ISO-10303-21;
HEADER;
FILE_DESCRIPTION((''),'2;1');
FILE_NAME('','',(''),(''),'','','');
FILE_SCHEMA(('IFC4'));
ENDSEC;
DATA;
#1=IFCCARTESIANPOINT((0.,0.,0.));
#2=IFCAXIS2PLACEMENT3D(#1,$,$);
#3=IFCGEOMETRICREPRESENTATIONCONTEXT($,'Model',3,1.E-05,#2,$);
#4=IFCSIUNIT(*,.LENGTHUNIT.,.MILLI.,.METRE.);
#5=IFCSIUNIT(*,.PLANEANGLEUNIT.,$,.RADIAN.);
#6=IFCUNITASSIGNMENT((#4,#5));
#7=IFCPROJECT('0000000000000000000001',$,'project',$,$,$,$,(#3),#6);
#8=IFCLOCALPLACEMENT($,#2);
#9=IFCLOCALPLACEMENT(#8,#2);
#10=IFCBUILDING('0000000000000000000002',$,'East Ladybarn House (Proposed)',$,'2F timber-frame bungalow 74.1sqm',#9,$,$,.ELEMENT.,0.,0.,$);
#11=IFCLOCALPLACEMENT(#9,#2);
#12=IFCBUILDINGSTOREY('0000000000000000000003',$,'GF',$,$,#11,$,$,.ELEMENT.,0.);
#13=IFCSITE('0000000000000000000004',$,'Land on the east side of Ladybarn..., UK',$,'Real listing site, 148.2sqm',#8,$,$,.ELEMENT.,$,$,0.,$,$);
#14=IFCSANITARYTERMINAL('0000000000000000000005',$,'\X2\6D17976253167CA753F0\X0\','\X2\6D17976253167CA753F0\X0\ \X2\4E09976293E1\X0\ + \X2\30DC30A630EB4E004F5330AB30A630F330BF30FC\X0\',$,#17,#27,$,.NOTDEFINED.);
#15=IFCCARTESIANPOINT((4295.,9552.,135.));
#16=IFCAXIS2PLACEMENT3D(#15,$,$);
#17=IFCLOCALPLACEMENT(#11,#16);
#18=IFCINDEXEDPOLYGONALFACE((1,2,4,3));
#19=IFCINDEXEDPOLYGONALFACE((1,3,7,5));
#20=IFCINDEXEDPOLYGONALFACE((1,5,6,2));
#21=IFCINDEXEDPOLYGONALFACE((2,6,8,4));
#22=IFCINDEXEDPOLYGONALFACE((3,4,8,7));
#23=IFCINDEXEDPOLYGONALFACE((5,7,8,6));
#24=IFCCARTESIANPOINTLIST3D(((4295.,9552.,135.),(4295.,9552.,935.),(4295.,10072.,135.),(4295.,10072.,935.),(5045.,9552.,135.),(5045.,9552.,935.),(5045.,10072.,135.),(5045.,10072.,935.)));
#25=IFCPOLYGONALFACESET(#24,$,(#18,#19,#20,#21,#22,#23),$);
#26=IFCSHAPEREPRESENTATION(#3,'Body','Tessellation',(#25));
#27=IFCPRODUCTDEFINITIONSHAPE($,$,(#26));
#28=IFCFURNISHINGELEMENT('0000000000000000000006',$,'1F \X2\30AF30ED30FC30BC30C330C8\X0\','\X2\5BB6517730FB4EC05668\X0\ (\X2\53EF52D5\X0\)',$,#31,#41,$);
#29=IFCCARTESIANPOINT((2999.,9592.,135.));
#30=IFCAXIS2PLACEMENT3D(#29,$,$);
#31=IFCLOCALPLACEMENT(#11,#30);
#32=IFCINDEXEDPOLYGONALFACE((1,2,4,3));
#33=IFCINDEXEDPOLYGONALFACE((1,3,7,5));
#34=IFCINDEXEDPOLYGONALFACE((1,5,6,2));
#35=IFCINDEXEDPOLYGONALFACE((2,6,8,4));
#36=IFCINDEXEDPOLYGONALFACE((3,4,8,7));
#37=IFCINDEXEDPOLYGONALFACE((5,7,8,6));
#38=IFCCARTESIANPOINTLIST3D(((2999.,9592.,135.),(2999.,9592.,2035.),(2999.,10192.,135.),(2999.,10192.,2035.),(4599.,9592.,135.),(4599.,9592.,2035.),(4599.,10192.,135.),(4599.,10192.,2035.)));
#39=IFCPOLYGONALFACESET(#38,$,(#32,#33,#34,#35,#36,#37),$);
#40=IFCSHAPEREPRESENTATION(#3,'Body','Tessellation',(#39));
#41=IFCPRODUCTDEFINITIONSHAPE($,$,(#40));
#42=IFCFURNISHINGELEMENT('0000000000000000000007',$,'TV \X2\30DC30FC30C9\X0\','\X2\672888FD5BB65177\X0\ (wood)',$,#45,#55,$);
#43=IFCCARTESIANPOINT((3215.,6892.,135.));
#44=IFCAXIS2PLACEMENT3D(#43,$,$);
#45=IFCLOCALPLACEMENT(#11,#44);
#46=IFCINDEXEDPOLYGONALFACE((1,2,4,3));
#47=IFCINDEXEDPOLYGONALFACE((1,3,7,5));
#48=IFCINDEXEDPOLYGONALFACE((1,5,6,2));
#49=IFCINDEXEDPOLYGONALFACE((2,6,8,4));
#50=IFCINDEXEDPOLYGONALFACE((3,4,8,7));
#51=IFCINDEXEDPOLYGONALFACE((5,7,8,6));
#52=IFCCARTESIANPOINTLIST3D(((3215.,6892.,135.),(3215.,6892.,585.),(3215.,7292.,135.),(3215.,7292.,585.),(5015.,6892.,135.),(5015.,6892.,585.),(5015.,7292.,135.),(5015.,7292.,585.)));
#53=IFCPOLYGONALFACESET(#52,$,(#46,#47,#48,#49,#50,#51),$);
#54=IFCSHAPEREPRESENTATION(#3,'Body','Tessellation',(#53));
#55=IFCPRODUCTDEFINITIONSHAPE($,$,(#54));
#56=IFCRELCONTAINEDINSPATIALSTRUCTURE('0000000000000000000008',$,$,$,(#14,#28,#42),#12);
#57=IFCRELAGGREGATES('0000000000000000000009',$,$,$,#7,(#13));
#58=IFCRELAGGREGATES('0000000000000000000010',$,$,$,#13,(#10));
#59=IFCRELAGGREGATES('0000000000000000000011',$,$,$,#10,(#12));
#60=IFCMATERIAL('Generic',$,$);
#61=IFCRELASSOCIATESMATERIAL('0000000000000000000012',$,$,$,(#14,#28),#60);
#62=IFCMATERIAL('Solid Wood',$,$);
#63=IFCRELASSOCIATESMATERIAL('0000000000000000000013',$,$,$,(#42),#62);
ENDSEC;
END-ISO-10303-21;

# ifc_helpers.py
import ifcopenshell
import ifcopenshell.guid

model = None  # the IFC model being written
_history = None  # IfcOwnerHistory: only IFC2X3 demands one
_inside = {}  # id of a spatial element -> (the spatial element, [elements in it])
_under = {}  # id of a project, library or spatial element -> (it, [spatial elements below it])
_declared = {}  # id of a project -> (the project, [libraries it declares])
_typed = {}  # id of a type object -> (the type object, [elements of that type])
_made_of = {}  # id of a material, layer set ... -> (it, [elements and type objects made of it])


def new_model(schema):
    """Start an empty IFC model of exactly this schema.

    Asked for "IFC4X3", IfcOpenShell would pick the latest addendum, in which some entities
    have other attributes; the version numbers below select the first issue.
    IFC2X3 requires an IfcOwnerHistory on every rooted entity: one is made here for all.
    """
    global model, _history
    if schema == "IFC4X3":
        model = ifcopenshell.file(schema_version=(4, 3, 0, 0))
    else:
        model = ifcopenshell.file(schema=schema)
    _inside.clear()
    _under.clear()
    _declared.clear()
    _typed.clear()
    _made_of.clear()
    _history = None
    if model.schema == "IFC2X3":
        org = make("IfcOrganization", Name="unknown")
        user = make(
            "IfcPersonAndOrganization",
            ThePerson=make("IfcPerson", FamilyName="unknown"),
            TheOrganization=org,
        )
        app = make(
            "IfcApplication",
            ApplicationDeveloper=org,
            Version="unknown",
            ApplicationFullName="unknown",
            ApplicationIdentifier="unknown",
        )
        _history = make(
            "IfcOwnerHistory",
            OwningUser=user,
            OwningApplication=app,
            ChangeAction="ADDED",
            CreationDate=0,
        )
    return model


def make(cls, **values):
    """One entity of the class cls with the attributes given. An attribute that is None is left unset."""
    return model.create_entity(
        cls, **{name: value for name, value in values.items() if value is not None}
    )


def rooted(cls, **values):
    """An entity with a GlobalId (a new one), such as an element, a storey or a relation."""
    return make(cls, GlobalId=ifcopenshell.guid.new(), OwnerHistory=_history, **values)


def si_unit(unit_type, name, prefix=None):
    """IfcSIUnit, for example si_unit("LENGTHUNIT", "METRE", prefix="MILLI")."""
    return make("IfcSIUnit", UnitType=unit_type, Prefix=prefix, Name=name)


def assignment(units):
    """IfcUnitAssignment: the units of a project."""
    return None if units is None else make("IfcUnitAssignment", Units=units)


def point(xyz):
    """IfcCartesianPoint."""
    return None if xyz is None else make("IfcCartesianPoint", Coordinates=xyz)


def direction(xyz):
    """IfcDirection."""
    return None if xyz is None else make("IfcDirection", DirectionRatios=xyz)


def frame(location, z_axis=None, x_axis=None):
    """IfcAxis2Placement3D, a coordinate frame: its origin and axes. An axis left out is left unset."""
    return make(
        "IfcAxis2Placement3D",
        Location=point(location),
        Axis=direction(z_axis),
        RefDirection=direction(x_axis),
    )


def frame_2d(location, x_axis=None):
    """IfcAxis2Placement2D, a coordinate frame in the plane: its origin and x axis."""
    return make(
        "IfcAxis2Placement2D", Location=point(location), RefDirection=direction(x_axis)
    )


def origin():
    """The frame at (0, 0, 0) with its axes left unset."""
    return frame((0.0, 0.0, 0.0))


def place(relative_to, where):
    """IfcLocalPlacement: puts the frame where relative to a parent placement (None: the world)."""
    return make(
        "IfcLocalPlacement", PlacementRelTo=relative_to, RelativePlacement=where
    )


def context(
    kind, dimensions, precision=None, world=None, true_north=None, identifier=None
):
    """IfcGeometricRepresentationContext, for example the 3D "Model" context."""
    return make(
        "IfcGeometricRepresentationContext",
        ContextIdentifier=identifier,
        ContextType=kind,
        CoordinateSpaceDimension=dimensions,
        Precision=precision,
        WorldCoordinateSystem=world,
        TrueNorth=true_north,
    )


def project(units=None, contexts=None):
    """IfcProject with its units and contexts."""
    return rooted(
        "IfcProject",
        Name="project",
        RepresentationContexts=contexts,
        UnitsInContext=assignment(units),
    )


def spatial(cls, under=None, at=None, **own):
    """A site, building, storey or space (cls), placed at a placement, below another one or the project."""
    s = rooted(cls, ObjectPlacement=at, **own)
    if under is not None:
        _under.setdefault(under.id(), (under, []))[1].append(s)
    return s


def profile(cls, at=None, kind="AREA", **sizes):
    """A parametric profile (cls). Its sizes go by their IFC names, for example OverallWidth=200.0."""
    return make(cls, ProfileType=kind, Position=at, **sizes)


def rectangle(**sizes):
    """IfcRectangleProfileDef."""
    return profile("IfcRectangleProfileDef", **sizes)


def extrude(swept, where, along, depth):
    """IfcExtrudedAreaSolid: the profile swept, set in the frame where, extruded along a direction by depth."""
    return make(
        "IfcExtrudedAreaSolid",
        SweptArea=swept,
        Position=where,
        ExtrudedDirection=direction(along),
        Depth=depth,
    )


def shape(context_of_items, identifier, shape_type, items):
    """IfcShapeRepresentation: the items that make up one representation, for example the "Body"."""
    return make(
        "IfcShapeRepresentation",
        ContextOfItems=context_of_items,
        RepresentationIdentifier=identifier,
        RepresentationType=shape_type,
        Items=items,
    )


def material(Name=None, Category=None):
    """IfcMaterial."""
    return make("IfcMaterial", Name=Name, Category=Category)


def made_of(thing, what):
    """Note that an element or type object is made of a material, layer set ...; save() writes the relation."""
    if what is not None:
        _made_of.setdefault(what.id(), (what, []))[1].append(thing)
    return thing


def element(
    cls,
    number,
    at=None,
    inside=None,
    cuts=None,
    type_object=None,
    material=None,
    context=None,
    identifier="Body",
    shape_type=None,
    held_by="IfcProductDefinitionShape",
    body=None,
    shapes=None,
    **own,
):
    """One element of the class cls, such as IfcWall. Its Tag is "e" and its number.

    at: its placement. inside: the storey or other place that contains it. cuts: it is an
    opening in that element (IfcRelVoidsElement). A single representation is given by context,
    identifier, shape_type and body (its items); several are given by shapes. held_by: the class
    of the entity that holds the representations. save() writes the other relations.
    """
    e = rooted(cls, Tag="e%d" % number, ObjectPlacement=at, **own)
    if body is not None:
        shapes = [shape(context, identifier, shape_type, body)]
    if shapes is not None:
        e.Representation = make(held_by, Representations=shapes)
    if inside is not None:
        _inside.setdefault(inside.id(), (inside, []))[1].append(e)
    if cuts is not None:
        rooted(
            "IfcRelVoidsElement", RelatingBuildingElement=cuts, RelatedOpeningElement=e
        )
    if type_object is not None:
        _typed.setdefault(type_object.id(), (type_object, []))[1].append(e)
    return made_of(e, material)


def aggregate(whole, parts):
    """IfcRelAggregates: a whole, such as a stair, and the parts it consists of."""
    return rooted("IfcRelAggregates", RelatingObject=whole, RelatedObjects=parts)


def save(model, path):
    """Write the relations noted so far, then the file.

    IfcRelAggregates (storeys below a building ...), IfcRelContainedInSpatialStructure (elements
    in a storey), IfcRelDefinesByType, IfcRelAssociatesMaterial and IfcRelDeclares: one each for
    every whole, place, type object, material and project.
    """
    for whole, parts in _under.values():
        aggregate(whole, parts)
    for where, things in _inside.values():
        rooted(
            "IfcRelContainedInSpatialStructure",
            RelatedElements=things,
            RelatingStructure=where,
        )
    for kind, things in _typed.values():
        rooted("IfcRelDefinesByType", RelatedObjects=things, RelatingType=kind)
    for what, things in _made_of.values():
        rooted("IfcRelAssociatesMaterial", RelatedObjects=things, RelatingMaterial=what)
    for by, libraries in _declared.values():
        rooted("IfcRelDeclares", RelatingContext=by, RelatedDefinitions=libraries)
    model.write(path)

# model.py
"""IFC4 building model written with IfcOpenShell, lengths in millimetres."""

from ifc_helpers import new_model, si_unit, frame, frame_2d, origin, place, context, project, spatial, rectangle, extrude, material, element, save


model = new_model("IFC4")

# Units and contexts
model_context = context("Model", 3, precision=1e-05, world=origin())
ifc_project = project(units=[si_unit("LENGTHUNIT", "METRE", prefix="MILLI"), si_unit("PLANEANGLEUNIT", "RADIAN")], contexts=[model_context])

# Site, building, storey
site_placement = place(None, origin())
site = spatial("IfcSite", under=ifc_project, at=site_placement, Name="Land on the east side of Ladybarn..., UK", ObjectType="Real listing site, 148.2sqm", CompositionType="ELEMENT", RefElevation=0.0)
building_placement = place(site_placement, origin())
building = spatial("IfcBuilding", under=site, at=building_placement, Name="East Ladybarn House (Proposed)", ObjectType="2F timber-frame bungalow 74.1sqm", CompositionType="ELEMENT", ElevationOfRefHeight=0.0, ElevationOfTerrain=0.0)
storey_placement = place(building_placement, origin())
storey = spatial("IfcBuildingStorey", under=building, at=storey_placement, Name="GF", CompositionType="ELEMENT", Elevation=0.0)

# Shared definitions
ifc_material_1 = material(Name="Solid Wood")

# Shared definitions
ifc_material_2 = material(Name="Generic")

# Sanitary terminal
sanitary_terminal_1_placement = place(storey_placement, frame((4295.0, 9552.0, 135.0)))
element("IfcSanitaryTerminal", 1, at=sanitary_terminal_1_placement, inside=storey, material=ifc_material_2, Name="洗面化粧台", Description="洗面化粧台 三面鏡 + ボウル一体カウンター", PredefinedType="NOTDEFINED", context=model_context, shape_type="SweptSolid", body=[
    extrude(rectangle(XDim=750.0, YDim=520.0, at=frame_2d((375.0, 260.0))), frame((4295.0, 9552.0, 135.0)), (0.0, 0.0, 1.0), 800.0),
])

# Furnishing elements
furnishing_1_placement = place(storey_placement, frame((2999.0, 9592.0, 135.0)))
element("IfcFurnishingElement", 2, at=furnishing_1_placement, inside=storey, material=ifc_material_2, Name="1F クローゼット", Description="家具・什器 (可動)", context=model_context, shape_type="SweptSolid", body=[
    extrude(rectangle(XDim=1600.0, YDim=600.0, at=frame_2d((800.0, 300.0))), frame((2999.0, 9592.0, 135.0)), (0.0, 0.0, 1.0), 1900.0),
])
furnishing_2_placement = place(storey_placement, frame((3215.0, 6892.0, 135.0)))
element("IfcFurnishingElement", 3, at=furnishing_2_placement, inside=storey, material=ifc_material_1, Name="TV ボード", Description="木製家具 (wood)", context=model_context, shape_type="SweptSolid", body=[
    extrude(rectangle(XDim=1800.0, YDim=400.0, at=frame_2d((900.0, 200.0))), frame((3215.0, 6892.0, 135.0)), (0.0, 0.0, 1.0), 450.0),
])

save(model, "model.ifc")
